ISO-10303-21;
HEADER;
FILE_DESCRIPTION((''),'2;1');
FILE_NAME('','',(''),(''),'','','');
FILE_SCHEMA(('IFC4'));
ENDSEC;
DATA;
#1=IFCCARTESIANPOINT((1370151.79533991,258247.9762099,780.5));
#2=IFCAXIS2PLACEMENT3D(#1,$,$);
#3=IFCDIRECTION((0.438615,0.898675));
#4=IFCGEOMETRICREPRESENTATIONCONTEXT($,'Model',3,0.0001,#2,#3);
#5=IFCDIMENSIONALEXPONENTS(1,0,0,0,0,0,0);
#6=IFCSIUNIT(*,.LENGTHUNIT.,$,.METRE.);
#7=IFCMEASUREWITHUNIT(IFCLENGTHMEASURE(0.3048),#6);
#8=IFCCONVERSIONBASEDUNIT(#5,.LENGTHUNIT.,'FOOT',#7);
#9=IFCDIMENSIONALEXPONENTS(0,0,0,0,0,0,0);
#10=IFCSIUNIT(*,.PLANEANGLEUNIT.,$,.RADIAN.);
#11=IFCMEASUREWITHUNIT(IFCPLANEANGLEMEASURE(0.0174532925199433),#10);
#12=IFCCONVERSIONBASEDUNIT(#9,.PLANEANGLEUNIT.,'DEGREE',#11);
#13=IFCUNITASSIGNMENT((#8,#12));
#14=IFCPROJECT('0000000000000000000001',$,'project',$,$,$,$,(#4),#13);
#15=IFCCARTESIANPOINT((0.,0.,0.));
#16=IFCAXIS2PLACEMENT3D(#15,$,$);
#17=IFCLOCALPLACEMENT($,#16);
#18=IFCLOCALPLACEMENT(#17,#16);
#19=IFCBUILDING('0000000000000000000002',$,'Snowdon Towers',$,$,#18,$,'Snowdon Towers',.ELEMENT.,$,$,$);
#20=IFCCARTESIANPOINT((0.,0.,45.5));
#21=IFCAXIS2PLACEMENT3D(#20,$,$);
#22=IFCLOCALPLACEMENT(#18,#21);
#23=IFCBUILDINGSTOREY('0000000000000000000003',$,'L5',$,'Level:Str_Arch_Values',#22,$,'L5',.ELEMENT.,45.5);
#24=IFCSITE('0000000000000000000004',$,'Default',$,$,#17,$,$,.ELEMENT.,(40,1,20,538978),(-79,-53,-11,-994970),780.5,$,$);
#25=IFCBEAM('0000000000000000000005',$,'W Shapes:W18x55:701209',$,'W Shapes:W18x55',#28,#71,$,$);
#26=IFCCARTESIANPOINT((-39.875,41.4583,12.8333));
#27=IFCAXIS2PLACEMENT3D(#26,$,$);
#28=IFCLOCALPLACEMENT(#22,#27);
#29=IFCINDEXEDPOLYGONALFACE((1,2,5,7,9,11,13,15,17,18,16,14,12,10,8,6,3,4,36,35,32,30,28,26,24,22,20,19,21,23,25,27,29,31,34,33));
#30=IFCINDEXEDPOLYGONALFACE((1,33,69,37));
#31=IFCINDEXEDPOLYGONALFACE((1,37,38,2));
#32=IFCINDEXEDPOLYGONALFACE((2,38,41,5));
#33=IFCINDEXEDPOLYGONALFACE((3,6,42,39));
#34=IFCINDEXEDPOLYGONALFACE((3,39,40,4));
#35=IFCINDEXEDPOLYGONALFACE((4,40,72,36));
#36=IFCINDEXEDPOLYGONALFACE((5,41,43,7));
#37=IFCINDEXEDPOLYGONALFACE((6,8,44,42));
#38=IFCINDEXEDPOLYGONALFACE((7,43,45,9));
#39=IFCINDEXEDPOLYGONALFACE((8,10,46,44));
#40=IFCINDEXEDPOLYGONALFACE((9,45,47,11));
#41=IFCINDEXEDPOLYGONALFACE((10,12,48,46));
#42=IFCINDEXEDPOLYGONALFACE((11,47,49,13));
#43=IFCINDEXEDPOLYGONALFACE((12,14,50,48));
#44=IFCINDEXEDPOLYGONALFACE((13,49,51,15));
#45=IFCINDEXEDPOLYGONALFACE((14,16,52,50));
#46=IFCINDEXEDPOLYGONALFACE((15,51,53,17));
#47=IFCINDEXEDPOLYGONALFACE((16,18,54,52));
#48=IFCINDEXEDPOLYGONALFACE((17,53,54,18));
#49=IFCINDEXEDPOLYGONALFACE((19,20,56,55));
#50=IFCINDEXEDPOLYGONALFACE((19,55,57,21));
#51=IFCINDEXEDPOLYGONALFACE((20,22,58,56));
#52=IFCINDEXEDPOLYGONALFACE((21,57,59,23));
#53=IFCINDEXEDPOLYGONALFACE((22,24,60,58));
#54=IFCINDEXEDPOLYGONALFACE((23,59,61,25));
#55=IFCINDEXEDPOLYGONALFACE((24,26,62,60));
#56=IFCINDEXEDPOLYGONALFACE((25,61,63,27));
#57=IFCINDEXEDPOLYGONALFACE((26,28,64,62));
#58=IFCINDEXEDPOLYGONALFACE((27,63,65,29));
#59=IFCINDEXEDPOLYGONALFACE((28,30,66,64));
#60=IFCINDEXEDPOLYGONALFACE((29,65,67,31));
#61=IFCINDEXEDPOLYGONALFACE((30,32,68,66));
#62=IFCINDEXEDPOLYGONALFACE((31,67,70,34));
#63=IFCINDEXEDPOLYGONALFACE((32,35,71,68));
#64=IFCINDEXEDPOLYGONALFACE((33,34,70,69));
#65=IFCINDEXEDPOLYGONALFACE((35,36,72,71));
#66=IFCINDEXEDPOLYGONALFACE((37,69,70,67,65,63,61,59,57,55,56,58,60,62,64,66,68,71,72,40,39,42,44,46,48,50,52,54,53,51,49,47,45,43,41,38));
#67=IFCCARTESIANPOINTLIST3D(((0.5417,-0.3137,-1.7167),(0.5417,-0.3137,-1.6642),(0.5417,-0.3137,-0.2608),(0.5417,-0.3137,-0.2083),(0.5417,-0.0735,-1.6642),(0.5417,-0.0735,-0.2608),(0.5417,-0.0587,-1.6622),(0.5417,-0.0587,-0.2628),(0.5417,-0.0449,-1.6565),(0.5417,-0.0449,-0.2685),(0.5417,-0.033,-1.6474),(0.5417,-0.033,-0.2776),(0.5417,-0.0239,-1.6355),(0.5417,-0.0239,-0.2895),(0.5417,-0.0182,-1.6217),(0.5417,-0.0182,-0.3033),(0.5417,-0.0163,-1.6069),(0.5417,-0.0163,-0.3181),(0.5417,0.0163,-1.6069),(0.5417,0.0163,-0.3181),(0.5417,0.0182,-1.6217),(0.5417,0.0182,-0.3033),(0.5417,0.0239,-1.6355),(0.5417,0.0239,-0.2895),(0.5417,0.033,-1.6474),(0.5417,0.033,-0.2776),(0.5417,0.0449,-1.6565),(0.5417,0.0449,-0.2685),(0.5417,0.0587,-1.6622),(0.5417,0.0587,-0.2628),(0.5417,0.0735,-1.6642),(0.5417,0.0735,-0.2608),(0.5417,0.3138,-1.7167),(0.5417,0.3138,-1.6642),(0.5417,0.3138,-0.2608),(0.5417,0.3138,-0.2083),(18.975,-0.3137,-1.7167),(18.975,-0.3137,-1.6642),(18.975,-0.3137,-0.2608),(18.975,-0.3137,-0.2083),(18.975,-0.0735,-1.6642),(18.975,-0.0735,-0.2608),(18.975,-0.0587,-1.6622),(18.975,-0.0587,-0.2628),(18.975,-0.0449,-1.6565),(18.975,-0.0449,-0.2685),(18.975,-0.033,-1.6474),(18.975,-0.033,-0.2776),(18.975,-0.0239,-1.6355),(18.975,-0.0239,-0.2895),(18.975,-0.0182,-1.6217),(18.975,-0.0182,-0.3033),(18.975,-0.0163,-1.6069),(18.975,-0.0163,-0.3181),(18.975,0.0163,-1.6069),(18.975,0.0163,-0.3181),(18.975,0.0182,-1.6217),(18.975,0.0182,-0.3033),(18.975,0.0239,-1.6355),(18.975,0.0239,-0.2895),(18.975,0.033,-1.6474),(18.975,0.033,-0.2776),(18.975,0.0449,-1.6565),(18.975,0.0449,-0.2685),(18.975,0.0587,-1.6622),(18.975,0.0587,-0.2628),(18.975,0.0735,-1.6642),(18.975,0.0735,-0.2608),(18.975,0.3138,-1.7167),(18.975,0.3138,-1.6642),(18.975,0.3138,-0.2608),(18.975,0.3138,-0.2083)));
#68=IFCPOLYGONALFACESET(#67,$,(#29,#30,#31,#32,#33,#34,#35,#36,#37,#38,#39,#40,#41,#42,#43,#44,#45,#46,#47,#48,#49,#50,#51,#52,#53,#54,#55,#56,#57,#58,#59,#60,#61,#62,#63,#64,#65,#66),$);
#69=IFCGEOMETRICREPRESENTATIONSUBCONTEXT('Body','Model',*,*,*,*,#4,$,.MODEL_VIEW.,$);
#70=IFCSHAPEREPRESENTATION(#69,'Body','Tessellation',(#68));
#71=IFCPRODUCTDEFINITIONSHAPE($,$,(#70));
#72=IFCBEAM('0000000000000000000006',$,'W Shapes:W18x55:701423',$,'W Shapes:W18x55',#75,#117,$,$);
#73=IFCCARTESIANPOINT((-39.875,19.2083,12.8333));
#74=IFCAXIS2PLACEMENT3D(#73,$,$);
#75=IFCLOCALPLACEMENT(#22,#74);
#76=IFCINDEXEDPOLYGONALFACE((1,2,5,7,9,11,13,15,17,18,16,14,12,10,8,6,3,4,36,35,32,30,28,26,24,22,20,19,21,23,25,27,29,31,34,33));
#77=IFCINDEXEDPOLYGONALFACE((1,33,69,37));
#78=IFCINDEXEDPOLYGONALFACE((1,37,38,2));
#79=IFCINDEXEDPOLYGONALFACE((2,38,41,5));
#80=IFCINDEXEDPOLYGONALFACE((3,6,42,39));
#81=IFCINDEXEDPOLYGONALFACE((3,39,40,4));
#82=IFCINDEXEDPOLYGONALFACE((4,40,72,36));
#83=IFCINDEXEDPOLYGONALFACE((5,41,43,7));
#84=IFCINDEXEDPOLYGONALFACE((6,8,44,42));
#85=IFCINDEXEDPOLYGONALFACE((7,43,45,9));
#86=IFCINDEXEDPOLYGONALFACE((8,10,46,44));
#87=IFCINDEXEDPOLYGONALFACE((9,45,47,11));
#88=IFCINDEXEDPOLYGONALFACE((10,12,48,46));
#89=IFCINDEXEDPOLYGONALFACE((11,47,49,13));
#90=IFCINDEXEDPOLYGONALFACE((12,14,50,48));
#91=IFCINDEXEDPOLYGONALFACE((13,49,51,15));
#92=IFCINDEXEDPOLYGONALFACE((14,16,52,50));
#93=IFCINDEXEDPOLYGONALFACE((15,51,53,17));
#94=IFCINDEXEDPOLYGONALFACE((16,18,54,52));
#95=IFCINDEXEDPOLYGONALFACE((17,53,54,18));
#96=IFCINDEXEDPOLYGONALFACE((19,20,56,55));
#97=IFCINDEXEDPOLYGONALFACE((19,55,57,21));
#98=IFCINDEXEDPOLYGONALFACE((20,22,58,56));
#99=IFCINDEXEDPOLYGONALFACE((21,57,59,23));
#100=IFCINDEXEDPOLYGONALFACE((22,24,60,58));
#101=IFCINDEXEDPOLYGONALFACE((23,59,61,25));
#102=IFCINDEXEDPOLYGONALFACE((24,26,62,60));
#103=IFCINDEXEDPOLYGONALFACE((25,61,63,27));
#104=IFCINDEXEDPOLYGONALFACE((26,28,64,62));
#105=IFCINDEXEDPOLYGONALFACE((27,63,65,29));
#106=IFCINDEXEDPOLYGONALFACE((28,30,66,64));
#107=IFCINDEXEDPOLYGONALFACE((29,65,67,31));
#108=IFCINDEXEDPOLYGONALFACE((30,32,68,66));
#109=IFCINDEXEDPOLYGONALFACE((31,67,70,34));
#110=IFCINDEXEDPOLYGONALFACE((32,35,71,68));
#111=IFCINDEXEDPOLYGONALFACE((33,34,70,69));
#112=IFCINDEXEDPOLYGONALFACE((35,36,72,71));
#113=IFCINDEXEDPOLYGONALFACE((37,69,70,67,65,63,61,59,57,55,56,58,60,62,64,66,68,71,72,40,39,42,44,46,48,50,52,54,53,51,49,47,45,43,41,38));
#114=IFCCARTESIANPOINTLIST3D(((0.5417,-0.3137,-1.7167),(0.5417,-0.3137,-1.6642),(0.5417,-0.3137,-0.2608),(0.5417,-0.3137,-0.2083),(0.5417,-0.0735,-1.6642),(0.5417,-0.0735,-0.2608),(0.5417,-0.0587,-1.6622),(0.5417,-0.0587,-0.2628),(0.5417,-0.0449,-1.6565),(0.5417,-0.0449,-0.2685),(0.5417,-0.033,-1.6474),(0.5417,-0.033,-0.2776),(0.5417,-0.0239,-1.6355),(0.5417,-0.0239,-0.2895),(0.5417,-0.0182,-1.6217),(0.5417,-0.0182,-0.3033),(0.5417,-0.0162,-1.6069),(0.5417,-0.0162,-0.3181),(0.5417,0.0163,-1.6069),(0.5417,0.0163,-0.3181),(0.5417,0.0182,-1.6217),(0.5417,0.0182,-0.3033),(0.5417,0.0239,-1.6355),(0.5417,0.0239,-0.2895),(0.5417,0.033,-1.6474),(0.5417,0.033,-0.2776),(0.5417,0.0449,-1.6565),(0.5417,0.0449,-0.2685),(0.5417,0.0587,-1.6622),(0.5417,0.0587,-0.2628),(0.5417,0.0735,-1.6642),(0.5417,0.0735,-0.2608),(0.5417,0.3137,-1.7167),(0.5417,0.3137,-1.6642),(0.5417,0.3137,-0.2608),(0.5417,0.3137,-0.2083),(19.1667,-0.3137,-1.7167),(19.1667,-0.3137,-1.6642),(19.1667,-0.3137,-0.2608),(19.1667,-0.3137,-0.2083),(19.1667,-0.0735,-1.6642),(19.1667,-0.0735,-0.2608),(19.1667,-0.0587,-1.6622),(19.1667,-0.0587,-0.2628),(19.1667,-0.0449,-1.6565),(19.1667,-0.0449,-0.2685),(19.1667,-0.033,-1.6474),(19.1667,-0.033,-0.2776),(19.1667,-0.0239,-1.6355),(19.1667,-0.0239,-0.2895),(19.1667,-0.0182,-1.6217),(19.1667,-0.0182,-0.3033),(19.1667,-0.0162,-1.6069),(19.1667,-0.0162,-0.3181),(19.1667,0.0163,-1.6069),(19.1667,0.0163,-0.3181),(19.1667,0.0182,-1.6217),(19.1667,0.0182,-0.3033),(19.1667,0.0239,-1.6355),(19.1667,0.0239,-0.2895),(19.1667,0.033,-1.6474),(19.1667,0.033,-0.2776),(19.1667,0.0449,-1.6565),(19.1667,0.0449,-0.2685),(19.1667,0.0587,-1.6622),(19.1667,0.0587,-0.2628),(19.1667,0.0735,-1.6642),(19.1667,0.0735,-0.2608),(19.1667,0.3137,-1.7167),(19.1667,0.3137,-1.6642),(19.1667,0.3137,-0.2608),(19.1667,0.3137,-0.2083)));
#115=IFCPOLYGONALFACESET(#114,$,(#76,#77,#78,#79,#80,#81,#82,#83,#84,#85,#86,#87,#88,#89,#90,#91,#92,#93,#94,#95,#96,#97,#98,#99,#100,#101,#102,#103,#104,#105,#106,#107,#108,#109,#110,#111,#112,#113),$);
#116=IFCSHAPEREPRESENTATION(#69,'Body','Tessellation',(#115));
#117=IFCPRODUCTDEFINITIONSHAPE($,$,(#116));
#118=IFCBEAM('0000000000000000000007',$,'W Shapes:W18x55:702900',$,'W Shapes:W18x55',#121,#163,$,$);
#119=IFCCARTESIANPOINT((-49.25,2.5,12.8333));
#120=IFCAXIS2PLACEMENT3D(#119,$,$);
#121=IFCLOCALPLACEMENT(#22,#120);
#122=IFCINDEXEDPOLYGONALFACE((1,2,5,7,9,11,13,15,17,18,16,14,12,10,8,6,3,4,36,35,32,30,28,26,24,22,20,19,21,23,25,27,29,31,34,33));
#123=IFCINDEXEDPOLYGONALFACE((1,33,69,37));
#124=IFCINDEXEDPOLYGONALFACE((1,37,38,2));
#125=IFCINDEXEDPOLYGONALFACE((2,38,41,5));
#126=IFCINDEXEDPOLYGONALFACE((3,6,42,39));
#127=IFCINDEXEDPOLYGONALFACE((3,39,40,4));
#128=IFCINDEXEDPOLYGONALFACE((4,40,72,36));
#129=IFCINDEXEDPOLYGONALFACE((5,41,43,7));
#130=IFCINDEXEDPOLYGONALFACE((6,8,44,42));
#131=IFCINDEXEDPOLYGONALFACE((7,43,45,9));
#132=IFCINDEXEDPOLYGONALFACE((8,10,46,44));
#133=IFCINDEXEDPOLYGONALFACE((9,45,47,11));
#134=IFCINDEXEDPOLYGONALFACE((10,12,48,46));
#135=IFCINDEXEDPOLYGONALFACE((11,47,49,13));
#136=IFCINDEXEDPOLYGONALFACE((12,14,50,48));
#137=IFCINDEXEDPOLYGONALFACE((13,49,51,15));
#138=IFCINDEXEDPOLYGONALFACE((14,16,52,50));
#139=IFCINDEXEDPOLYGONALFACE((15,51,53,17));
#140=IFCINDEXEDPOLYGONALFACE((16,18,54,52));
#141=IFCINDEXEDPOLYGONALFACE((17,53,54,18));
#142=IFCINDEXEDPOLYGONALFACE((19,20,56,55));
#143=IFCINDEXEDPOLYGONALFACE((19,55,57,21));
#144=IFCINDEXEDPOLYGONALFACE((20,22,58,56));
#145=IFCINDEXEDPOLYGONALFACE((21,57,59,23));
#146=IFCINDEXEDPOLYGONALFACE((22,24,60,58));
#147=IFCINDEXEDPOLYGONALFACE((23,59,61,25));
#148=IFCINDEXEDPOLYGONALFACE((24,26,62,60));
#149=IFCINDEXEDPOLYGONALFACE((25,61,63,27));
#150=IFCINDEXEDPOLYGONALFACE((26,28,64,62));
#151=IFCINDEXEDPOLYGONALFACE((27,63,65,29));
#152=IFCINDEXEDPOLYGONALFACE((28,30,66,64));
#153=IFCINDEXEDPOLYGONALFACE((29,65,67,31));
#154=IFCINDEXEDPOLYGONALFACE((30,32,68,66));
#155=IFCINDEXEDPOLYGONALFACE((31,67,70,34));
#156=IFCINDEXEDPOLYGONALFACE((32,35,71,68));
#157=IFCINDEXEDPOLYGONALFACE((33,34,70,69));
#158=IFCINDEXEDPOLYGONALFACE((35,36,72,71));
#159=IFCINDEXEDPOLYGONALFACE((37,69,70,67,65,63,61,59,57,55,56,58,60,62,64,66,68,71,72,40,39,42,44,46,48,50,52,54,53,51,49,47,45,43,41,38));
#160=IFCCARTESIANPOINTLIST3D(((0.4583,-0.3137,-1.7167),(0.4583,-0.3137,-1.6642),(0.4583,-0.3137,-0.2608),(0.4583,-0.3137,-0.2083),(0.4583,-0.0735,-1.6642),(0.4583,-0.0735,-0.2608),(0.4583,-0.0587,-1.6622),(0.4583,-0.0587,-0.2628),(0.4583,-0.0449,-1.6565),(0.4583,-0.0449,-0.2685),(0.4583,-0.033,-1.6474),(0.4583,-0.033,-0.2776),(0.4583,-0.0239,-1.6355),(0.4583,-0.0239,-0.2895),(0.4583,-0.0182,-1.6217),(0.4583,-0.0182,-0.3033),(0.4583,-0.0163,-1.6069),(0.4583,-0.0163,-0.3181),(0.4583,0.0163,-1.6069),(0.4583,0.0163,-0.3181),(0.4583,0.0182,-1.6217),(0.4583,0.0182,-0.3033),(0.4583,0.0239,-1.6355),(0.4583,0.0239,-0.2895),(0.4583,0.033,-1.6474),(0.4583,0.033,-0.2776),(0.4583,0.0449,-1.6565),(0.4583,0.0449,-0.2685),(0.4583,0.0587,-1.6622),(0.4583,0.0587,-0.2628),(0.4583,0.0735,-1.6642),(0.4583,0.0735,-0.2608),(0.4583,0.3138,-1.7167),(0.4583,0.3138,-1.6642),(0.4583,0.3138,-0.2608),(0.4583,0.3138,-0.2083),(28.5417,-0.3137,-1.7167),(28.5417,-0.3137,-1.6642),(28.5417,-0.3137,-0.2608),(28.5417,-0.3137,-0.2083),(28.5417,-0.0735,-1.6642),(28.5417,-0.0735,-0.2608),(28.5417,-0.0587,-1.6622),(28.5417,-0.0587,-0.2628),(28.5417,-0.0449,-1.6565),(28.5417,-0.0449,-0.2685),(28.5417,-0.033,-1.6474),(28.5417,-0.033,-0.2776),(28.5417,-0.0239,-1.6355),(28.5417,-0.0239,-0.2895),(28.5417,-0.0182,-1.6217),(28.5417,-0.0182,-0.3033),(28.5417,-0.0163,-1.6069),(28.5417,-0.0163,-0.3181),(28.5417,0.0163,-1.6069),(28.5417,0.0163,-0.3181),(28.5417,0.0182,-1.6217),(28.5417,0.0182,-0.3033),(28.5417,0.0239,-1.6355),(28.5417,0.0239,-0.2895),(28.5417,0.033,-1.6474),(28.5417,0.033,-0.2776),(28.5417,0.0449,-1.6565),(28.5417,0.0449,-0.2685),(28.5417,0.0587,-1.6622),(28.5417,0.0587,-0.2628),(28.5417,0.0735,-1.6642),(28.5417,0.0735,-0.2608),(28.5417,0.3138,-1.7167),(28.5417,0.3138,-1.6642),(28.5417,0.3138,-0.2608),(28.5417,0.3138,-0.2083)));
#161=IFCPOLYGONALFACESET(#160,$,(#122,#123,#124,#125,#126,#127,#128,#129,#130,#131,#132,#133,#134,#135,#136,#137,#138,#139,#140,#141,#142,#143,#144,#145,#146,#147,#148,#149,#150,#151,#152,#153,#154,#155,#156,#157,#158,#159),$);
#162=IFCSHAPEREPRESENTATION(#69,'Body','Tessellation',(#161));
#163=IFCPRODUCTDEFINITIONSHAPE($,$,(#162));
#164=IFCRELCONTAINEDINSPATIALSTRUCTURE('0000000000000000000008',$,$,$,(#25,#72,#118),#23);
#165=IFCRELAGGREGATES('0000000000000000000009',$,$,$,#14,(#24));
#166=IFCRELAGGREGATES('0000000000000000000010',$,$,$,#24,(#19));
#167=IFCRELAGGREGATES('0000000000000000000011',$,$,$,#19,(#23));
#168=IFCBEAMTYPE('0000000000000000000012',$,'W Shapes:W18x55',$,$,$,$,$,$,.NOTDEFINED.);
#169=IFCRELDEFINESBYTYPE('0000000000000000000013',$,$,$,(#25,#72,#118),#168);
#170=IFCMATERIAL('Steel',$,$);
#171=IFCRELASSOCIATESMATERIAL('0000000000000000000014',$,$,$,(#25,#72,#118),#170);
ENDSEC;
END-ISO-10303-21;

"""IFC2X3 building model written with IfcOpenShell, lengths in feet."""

from ifc_helpers import new_model, entity, si_unit, converted_unit, direction, frame, frame_2d, origin, place, context, subcontext, project, spatial, i_section, extrude, material, type_object, element, save


model = new_model("IFC2X3")

# Units and contexts
model_context = context("Model", 3, precision=0.0001, world=frame((1370151.79533991, 258247.9762099, 780.5)), true_north=direction((0.438615, 0.898675)))
body_context = subcontext(model_context, "Body", "Model", "MODEL_VIEW")
ifc_project = project(units=[converted_unit("LENGTHUNIT", "FOOT", entity("IfcLengthMeasure", 0.3048), si_unit("LENGTHUNIT", "METRE"), dimensions=[1, 0, 0, 0, 0, 0, 0]), converted_unit("PLANEANGLEUNIT", "DEGREE", entity("IfcPlaneAngleMeasure", 0.0174532925199433), si_unit("PLANEANGLEUNIT", "RADIAN"), dimensions=[0, 0, 0, 0, 0, 0, 0])], contexts=[model_context])

# Site, building, storey
site_placement = place(None, origin())
site = spatial("IfcSite", under=ifc_project, at=site_placement, Name="Default", CompositionType="ELEMENT", RefLatitude=(40, 1, 20, 538978), RefLongitude=(-79, -53, -11, -994970), RefElevation=780.5)
building_placement = place(site_placement, origin())
building = spatial("IfcBuilding", under=site, at=building_placement, Name="Snowdon Towers", LongName="Snowdon Towers", CompositionType="ELEMENT")
storey_placement = place(building_placement, frame((0.0, 0.0, 45.5)))
storey = spatial("IfcBuildingStorey", under=building, at=storey_placement, Name="L5", ObjectType="Level:Str_Arch_Values", LongName="L5", CompositionType="ELEMENT", Elevation=45.5)

# Beams
ifc_material_1 = material(Name="Steel")
beam_type_1 = type_object("IfcBeamType", Name="W Shapes:W18x55", PredefinedType="NOTDEFINED")
beam_1_placement = place(storey_placement, frame((-39.875, 41.4583, 12.8333)))
element("IfcBeam", 1, at=beam_1_placement, inside=storey, type_object=beam_type_1, material=ifc_material_1, Name="W Shapes:W18x55:701209", ObjectType="W Shapes:W18x55", context=body_context, shape_type="SweptSolid", body=[
    extrude(i_section(OverallWidth=0.6275, OverallDepth=1.5083, WebThickness=0.0325, FlangeThickness=0.0525, FilletRadius=0.0573, at=frame_2d((0.0, 0.0), x_axis=(0.0, 1.0))), frame((0.5417, 0.0, -0.9625), z_axis=(1.0, 0.0, 0.0), x_axis=(0.0, 0.0, -1.0)), (0.0, 0.0, 1.0), 18.4333),
])
beam_2_placement = place(storey_placement, frame((-39.875, 19.2083, 12.8333)))
element("IfcBeam", 2, at=beam_2_placement, inside=storey, type_object=beam_type_1, material=ifc_material_1, Name="W Shapes:W18x55:701423", ObjectType="W Shapes:W18x55", context=body_context, shape_type="SweptSolid", body=[
    extrude(i_section(OverallWidth=0.6275, OverallDepth=1.5083, WebThickness=0.0325, FlangeThickness=0.0525, FilletRadius=0.0573, at=frame_2d((0.0, 0.0), x_axis=(0.0, 1.0))), frame((0.5417, 0.0, -0.9625), z_axis=(1.0, 0.0, 0.0), x_axis=(0.0, 0.0, -1.0)), (0.0, 0.0, 1.0), 18.625),
])
beam_3_placement = place(storey_placement, frame((-49.25, 2.5, 12.8333)))
element("IfcBeam", 3, at=beam_3_placement, inside=storey, type_object=beam_type_1, material=ifc_material_1, Name="W Shapes:W18x55:702900", ObjectType="W Shapes:W18x55", context=body_context, shape_type="SweptSolid", body=[
    extrude(i_section(OverallWidth=0.6275, OverallDepth=1.5083, WebThickness=0.0325, FlangeThickness=0.0525, FilletRadius=0.0573, at=frame_2d((0.0, 0.0), x_axis=(0.0, 1.0))), frame((0.4583, 0.0, -0.9625), z_axis=(1.0, 0.0, 0.0), x_axis=(0.0, 0.0, -1.0)), (0.0, 0.0, 1.0), 28.0833),
])

save(model, "model.ifc")
